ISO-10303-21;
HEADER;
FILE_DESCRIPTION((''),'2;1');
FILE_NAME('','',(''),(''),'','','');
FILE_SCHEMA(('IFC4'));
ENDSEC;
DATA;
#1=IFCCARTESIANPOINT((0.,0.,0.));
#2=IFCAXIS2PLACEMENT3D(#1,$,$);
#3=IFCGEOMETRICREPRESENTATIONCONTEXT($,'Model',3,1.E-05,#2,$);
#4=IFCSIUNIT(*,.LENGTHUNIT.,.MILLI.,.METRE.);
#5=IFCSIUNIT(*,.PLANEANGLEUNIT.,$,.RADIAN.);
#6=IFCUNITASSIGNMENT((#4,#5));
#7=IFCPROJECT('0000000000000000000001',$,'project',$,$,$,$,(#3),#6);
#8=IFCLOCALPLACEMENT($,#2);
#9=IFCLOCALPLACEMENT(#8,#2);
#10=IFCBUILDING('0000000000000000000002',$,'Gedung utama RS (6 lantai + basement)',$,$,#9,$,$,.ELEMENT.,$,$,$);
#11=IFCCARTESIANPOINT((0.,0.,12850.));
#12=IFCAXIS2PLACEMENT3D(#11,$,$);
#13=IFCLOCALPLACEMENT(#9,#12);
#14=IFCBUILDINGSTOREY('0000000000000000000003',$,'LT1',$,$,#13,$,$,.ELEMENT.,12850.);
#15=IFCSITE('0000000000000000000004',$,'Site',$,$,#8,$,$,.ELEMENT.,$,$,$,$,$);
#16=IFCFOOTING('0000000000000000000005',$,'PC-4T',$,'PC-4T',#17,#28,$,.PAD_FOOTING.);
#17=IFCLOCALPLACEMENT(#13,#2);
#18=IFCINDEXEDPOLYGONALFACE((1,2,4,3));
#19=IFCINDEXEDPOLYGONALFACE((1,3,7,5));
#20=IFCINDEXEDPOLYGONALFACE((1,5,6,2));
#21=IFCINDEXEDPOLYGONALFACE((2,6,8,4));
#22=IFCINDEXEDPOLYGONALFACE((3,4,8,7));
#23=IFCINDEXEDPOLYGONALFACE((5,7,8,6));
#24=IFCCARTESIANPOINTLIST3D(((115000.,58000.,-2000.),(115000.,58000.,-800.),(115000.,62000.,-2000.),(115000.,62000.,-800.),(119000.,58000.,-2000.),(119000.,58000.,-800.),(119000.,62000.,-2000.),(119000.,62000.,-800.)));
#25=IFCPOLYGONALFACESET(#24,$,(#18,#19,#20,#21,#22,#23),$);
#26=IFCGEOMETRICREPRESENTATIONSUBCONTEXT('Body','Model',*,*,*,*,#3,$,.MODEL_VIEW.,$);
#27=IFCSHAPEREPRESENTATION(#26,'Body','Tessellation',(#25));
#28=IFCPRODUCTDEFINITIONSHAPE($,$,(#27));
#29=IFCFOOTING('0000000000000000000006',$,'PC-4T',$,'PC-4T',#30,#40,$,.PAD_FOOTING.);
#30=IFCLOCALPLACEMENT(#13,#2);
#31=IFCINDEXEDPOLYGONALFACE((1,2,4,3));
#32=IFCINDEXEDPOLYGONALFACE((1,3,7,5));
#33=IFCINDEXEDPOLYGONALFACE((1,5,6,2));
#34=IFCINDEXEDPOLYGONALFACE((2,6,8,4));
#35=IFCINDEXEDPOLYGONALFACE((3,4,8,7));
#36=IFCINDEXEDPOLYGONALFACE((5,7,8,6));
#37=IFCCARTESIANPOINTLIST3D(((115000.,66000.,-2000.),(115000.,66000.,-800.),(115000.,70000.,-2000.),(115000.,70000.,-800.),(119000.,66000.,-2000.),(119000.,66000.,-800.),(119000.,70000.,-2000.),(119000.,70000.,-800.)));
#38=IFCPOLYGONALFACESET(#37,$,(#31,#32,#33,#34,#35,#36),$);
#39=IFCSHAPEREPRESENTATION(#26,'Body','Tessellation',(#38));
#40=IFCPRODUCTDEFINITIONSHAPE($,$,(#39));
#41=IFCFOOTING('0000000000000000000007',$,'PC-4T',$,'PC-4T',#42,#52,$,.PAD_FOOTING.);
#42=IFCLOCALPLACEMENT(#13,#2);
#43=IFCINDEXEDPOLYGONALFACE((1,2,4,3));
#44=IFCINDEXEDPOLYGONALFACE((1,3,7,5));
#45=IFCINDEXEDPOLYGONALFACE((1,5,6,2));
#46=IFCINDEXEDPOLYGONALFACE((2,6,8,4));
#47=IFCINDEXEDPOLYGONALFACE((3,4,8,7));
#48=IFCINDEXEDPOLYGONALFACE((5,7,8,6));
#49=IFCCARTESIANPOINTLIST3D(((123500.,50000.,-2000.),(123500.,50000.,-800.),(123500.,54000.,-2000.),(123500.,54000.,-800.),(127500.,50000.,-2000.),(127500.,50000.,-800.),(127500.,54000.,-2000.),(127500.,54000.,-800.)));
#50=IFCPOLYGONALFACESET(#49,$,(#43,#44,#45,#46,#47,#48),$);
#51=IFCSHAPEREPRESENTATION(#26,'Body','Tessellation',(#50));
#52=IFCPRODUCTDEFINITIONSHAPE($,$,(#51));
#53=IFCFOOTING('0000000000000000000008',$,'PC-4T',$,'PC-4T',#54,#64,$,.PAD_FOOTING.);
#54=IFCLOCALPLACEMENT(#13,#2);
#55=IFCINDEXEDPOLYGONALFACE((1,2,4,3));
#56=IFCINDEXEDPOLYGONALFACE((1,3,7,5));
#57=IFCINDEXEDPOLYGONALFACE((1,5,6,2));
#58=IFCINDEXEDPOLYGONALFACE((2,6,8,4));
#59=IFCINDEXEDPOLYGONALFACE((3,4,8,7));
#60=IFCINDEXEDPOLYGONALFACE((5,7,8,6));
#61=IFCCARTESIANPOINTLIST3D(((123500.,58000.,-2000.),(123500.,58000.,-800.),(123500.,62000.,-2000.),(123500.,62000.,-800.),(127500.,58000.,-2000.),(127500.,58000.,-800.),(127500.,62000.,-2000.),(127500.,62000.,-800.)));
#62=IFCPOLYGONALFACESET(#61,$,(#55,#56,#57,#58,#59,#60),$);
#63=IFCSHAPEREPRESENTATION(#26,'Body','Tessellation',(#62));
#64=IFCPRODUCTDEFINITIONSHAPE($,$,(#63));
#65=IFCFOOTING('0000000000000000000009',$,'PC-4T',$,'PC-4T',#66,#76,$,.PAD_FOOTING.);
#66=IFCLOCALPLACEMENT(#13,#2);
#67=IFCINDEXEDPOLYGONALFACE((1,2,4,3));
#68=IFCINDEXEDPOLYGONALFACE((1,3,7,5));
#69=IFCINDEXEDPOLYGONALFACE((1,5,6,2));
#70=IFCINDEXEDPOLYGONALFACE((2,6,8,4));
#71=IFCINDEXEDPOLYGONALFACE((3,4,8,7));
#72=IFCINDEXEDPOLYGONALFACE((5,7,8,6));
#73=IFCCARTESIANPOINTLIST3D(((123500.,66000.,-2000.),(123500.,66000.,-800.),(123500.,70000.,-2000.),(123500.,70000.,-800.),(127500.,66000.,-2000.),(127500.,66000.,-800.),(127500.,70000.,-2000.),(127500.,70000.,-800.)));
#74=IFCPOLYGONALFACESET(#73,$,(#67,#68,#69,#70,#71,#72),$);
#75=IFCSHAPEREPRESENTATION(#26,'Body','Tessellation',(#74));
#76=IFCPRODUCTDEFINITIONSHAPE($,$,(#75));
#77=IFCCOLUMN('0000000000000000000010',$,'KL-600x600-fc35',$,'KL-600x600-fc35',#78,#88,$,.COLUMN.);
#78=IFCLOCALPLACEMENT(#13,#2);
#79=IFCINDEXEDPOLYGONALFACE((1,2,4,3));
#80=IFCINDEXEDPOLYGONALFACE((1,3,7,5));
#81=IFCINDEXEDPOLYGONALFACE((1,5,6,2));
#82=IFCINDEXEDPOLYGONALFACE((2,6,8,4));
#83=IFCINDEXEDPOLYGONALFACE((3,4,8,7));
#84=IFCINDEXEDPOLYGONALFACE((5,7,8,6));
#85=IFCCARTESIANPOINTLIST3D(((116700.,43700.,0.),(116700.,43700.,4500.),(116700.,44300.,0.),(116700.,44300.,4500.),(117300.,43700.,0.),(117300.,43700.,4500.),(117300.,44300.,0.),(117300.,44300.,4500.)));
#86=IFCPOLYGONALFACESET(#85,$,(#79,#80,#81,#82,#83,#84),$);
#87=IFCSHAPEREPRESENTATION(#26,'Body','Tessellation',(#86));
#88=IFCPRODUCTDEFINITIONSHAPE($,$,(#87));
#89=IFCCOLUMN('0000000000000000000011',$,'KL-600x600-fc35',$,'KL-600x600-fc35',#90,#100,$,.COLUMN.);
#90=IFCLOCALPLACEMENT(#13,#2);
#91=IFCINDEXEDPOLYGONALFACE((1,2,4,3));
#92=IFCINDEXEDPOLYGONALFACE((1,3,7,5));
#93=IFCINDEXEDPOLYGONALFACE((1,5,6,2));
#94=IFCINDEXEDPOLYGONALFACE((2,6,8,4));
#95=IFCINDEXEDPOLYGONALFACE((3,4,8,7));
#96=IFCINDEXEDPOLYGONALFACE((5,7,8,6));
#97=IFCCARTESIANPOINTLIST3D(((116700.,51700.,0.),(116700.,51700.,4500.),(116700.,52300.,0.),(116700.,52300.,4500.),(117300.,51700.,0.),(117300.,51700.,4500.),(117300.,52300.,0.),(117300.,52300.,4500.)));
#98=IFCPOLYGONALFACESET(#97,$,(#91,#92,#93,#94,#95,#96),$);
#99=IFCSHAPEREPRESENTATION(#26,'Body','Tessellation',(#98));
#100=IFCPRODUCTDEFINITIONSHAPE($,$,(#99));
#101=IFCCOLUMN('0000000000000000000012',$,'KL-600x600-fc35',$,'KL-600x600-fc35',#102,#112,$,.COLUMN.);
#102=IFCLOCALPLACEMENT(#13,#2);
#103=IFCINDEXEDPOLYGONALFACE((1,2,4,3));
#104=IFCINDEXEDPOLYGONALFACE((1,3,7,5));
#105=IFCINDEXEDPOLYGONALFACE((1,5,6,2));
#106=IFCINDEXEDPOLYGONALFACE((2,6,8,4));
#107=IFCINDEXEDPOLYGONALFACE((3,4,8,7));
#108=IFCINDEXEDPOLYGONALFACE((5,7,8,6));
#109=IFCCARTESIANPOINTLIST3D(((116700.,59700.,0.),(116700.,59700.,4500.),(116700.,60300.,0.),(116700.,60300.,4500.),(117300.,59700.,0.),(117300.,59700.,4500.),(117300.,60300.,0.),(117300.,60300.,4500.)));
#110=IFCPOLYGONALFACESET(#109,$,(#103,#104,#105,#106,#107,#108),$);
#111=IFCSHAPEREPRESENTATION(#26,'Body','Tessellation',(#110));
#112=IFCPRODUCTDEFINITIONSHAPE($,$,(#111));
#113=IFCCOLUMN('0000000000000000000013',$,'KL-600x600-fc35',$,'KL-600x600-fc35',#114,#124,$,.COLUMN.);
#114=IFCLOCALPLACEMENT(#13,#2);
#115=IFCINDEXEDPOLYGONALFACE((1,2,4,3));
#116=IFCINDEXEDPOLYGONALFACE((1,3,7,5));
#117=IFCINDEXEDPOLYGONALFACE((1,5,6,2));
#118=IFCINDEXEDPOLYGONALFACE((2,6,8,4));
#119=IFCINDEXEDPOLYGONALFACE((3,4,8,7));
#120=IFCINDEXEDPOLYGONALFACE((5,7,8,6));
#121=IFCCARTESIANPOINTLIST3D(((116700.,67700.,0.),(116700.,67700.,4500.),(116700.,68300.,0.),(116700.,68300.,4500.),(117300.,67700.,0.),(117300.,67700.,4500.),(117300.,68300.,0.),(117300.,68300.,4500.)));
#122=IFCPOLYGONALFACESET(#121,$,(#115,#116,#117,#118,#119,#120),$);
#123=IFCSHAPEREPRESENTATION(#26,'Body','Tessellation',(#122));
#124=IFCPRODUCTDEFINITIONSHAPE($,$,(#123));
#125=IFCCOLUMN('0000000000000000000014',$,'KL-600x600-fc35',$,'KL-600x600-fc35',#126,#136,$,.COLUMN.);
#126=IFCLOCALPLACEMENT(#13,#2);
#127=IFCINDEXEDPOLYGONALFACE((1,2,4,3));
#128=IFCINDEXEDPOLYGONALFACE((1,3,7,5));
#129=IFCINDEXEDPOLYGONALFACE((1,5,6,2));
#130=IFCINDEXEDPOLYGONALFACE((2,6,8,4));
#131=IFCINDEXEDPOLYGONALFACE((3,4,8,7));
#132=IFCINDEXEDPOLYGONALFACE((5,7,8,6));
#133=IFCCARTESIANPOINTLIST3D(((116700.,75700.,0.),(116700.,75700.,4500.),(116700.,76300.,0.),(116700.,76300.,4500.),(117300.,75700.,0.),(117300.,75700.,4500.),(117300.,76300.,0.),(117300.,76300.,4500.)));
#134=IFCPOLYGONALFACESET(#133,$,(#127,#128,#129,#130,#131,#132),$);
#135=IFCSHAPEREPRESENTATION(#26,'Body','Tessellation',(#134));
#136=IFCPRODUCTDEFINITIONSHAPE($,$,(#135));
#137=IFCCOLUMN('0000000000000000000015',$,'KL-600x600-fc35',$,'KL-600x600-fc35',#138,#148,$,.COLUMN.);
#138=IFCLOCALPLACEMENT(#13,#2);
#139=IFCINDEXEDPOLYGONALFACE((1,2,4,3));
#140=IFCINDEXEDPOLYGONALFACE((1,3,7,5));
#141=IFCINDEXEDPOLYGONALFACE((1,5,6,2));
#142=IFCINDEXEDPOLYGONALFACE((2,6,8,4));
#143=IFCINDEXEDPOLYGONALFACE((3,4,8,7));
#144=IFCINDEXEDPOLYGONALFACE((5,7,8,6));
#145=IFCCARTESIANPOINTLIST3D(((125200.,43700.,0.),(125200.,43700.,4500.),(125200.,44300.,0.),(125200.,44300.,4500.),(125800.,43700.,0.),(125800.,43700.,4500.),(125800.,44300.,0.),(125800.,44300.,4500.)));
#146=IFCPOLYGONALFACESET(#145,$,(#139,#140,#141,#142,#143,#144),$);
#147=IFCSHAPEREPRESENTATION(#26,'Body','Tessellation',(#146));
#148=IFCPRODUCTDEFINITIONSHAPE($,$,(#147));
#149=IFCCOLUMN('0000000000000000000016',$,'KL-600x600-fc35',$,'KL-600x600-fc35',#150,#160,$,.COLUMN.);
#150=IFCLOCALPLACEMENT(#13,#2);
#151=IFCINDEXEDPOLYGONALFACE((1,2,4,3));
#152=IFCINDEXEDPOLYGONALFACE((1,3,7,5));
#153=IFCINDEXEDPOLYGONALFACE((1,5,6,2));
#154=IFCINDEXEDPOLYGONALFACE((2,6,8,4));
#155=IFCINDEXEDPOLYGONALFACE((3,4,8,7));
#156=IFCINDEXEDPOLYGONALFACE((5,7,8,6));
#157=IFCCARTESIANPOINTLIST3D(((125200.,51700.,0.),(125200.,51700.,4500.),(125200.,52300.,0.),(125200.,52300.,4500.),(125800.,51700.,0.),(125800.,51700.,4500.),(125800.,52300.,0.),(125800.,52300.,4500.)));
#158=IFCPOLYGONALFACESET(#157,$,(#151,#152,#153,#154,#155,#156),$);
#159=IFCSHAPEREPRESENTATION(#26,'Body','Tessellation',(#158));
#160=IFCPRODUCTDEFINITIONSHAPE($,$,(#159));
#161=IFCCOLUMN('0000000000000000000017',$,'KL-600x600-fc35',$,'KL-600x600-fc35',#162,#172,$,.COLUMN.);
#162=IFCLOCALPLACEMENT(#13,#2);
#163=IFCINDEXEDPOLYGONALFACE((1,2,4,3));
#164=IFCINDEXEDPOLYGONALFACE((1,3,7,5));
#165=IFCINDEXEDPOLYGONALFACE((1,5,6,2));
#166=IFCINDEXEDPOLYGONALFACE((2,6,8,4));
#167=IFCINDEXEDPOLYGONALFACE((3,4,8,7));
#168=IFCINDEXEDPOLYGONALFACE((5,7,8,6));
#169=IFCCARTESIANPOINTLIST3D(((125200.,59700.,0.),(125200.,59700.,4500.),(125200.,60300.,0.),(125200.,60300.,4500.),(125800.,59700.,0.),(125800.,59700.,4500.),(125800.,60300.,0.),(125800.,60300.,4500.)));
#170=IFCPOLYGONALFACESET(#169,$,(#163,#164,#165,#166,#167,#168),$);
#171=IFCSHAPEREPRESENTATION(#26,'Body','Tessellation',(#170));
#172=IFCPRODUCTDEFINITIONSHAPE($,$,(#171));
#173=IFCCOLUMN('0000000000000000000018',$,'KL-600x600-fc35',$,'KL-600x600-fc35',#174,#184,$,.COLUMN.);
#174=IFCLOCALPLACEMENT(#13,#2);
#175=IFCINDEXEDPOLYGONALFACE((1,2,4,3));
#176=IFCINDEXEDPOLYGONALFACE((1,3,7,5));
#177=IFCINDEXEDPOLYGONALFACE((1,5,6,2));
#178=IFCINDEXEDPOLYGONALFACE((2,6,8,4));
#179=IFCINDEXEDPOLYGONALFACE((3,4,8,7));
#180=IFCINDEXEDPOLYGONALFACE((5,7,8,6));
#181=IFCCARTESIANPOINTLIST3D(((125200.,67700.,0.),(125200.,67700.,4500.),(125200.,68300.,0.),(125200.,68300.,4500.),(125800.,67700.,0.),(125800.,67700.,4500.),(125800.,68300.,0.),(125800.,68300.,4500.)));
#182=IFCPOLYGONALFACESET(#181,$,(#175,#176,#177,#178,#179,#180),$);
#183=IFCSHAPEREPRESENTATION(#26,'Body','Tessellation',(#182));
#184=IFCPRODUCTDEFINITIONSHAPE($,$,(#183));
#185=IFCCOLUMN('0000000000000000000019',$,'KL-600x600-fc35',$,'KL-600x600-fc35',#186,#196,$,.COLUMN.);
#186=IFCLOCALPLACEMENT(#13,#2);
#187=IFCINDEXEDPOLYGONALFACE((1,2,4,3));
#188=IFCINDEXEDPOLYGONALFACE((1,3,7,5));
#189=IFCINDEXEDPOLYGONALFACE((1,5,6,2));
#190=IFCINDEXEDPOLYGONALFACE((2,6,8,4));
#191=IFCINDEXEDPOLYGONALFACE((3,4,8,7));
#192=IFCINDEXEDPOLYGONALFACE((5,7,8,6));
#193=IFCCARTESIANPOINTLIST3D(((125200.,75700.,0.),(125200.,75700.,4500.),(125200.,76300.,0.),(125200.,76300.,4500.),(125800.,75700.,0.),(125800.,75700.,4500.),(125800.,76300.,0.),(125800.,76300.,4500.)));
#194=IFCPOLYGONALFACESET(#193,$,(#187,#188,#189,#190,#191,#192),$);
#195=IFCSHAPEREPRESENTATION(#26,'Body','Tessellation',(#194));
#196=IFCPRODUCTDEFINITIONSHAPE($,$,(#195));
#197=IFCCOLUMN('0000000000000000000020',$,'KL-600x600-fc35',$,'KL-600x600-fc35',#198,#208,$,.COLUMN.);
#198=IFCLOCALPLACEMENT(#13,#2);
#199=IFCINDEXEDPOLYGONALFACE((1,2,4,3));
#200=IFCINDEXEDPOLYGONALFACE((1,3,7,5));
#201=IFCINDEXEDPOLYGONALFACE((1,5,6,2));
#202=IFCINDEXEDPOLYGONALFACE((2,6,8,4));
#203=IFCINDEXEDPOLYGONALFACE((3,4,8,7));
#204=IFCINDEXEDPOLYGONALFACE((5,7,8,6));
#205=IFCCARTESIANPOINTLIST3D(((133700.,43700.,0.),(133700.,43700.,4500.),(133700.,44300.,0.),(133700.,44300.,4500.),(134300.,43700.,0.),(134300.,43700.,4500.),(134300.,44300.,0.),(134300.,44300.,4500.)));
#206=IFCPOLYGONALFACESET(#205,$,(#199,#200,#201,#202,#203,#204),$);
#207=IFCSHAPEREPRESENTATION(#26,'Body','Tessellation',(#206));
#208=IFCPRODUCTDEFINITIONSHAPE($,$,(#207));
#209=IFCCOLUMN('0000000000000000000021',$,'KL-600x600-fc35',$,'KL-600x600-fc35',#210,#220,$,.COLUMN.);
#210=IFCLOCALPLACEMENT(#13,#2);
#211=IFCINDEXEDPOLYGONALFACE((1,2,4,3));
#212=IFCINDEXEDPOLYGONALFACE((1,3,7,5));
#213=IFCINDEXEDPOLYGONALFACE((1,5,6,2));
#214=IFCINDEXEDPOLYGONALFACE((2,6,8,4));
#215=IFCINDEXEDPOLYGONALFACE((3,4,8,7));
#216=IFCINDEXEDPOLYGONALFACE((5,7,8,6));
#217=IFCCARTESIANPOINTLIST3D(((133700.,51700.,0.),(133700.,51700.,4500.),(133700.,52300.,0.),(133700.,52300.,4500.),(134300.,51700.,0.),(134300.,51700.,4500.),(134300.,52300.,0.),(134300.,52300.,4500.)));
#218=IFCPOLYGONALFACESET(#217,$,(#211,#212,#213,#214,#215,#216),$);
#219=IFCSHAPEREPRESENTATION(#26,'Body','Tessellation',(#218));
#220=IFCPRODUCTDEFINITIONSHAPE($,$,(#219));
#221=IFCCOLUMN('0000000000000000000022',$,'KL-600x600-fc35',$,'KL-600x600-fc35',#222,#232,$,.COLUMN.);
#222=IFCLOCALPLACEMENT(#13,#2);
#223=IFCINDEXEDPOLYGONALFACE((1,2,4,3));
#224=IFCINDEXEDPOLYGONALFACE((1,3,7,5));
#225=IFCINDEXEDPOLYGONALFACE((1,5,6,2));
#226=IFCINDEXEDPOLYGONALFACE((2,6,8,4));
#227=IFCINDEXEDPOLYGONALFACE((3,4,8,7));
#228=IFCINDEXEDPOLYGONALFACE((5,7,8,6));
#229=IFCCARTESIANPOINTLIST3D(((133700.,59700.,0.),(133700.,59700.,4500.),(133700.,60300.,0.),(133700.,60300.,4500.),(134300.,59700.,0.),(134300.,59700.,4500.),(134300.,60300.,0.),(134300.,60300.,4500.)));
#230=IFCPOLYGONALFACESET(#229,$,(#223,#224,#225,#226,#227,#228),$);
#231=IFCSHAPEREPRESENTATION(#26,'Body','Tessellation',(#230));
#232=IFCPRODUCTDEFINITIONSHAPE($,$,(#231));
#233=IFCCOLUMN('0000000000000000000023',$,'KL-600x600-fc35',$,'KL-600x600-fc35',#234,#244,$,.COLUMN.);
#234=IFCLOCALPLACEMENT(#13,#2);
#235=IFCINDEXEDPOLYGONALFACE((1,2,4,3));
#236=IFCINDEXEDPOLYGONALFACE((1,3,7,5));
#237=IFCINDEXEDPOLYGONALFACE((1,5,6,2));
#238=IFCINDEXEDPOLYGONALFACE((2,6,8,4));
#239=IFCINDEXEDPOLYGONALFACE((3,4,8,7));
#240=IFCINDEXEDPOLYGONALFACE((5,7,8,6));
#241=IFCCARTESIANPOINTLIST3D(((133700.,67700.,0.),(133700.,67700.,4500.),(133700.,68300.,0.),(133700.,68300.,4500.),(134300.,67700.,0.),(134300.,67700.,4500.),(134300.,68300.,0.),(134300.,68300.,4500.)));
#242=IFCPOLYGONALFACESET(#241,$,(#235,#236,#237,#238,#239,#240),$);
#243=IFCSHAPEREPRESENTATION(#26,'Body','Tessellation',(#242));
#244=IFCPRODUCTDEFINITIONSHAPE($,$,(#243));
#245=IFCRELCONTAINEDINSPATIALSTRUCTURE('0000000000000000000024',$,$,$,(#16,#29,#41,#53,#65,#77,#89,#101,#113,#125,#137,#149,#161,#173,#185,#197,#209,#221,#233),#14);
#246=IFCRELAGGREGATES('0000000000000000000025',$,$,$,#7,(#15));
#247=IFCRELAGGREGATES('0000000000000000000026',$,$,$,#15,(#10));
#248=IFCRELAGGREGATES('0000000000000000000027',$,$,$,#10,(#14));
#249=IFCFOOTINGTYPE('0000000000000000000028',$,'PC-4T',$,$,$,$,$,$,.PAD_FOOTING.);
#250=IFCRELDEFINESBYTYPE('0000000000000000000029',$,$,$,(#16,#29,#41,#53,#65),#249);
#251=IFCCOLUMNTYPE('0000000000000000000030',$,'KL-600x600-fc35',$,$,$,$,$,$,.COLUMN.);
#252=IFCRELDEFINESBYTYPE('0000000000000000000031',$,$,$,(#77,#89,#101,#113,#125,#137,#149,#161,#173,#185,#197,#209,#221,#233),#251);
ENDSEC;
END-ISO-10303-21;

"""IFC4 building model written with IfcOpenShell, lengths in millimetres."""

from ifc_helpers import new_model, si_unit, frame, origin, origin_2d, place, context, subcontext, project, spatial, rectangle, extrude, material_profile, profile_set, profile_usage, type_object, element, save


model = new_model("IFC4")

# Units and contexts
model_context = context("Model", 3, precision=1e-05, world=origin())
body_context = subcontext(model_context, "Body", "Model", "MODEL_VIEW")
ifc_project = project(units=[si_unit("LENGTHUNIT", "METRE", prefix="MILLI"), si_unit("PLANEANGLEUNIT", "RADIAN")], contexts=[model_context])

# Site, building, storey
site_placement = place(None, origin())
site = spatial("IfcSite", under=ifc_project, at=site_placement, Name="Site", CompositionType="ELEMENT")
building_placement = place(site_placement, origin())
building = spatial("IfcBuilding", under=site, at=building_placement, Name="Gedung utama RS (6 lantai + basement)", CompositionType="ELEMENT")
storey_placement = place(building_placement, frame((0.0, 0.0, 12850.0)))
storey = spatial("IfcBuildingStorey", under=building, at=storey_placement, Name="LT1", CompositionType="ELEMENT", Elevation=12850.0)

# Footings
ifc_material_profile_1 = material_profile(None, rectangle(XDim=4000.0, YDim=4000.0, at=origin_2d()), Name="PC-4T")
ifc_profile_set_1 = profile_set([ifc_material_profile_1], Name="PC-4T")
ifc_profile_usage_1 = profile_usage(ifc_profile_set_1, cardinal=5)
footing_type_1 = type_object("IfcFootingType", Name="PC-4T", PredefinedType="PAD_FOOTING", material=ifc_profile_set_1)
for number, where, z_axis, x_axis, name in (
    (1, (117000.0, 60000.0, -2000.0), (0.0, 0.0, 1.0), (1.0, 0.0, 0.0), "PC-4T"),
    (2, (117000.0, 68000.0, -2000.0), (0.0, 0.0, 1.0), (1.0, 0.0, 0.0), "PC-4T"),
    (3, (125500.0, 52000.0, -2000.0), (0.0, 0.0, 1.0), (1.0, 0.0, 0.0), "PC-4T"),
    (4, (125500.0, 60000.0, -2000.0), (0.0, 0.0, 1.0), (1.0, 0.0, 0.0), "PC-4T"),
    (5, (125500.0, 68000.0, -2000.0), (0.0, 0.0, 1.0), (1.0, 0.0, 0.0), "PC-4T"),
):
    element("IfcFooting", number, at=place(storey_placement, frame(where, z_axis=z_axis, x_axis=x_axis)), inside=storey, type_object=footing_type_1, material=ifc_profile_usage_1, Name=name, ObjectType="PC-4T", PredefinedType="PAD_FOOTING", context=body_context, shape_type="SweptSolid", body=[
        extrude(rectangle(XDim=4000.0, YDim=4000.0, at=origin_2d()), origin(), (0.0, 0.0, 1.0), 1200.0),
    ])

# Columns
ifc_material_profile_2 = material_profile(None, rectangle(XDim=600.0, YDim=600.0, at=origin_2d()), Name="KL-600x600-fc35")
ifc_profile_set_2 = profile_set([ifc_material_profile_2], Name="KL-600x600-fc35")
ifc_profile_usage_2 = profile_usage(ifc_profile_set_2, cardinal=5)
column_type = type_object("IfcColumnType", Name="KL-600x600-fc35", PredefinedType="COLUMN", material=ifc_profile_set_2)
for number, where, z_axis, x_axis, name in (
    (6, (117000.0, 44000.0, 0.0), (0.0, 0.0, 1.0), (1.0, 0.0, 0.0), "KL-600x600-fc35"),
    (7, (117000.0, 52000.0, 0.0), (0.0, 0.0, 1.0), (1.0, 0.0, 0.0), "KL-600x600-fc35"),
    (8, (117000.0, 60000.0, 0.0), (0.0, 0.0, 1.0), (1.0, 0.0, 0.0), "KL-600x600-fc35"),
    (9, (117000.0, 68000.0, 0.0), (0.0, 0.0, 1.0), (1.0, 0.0, 0.0), "KL-600x600-fc35"),
    (10, (117000.0, 76000.0, 0.0), (0.0, 0.0, 1.0), (1.0, 0.0, 0.0), "KL-600x600-fc35"),
    (11, (125500.0, 44000.0, 0.0), (0.0, 0.0, 1.0), (1.0, 0.0, 0.0), "KL-600x600-fc35"),
    (12, (125500.0, 52000.0, 0.0), (0.0, 0.0, 1.0), (1.0, 0.0, 0.0), "KL-600x600-fc35"),
    (13, (125500.0, 60000.0, 0.0), (0.0, 0.0, 1.0), (1.0, 0.0, 0.0), "KL-600x600-fc35"),
    (14, (125500.0, 68000.0, 0.0), (0.0, 0.0, 1.0), (1.0, 0.0, 0.0), "KL-600x600-fc35"),
    (15, (125500.0, 76000.0, 0.0), (0.0, 0.0, 1.0), (1.0, 0.0, 0.0), "KL-600x600-fc35"),
    (16, (134000.0, 44000.0, 0.0), (0.0, 0.0, 1.0), (1.0, 0.0, 0.0), "KL-600x600-fc35"),
    (17, (134000.0, 52000.0, 0.0), (0.0, 0.0, 1.0), (1.0, 0.0, 0.0), "KL-600x600-fc35"),
    (18, (134000.0, 60000.0, 0.0), (0.0, 0.0, 1.0), (1.0, 0.0, 0.0), "KL-600x600-fc35"),
    (19, (134000.0, 68000.0, 0.0), (0.0, 0.0, 1.0), (1.0, 0.0, 0.0), "KL-600x600-fc35"),
):
    element("IfcColumn", number, at=place(storey_placement, frame(where, z_axis=z_axis, x_axis=x_axis)), inside=storey, type_object=column_type, material=ifc_profile_usage_2, Name=name, ObjectType="KL-600x600-fc35", PredefinedType="COLUMN", context=body_context, shape_type="SweptSolid", body=[
        extrude(rectangle(XDim=600.0, YDim=600.0, at=origin_2d()), origin(), (0.0, 0.0, 1.0), 4500.0),
    ])

save(model, "model.ifc")
